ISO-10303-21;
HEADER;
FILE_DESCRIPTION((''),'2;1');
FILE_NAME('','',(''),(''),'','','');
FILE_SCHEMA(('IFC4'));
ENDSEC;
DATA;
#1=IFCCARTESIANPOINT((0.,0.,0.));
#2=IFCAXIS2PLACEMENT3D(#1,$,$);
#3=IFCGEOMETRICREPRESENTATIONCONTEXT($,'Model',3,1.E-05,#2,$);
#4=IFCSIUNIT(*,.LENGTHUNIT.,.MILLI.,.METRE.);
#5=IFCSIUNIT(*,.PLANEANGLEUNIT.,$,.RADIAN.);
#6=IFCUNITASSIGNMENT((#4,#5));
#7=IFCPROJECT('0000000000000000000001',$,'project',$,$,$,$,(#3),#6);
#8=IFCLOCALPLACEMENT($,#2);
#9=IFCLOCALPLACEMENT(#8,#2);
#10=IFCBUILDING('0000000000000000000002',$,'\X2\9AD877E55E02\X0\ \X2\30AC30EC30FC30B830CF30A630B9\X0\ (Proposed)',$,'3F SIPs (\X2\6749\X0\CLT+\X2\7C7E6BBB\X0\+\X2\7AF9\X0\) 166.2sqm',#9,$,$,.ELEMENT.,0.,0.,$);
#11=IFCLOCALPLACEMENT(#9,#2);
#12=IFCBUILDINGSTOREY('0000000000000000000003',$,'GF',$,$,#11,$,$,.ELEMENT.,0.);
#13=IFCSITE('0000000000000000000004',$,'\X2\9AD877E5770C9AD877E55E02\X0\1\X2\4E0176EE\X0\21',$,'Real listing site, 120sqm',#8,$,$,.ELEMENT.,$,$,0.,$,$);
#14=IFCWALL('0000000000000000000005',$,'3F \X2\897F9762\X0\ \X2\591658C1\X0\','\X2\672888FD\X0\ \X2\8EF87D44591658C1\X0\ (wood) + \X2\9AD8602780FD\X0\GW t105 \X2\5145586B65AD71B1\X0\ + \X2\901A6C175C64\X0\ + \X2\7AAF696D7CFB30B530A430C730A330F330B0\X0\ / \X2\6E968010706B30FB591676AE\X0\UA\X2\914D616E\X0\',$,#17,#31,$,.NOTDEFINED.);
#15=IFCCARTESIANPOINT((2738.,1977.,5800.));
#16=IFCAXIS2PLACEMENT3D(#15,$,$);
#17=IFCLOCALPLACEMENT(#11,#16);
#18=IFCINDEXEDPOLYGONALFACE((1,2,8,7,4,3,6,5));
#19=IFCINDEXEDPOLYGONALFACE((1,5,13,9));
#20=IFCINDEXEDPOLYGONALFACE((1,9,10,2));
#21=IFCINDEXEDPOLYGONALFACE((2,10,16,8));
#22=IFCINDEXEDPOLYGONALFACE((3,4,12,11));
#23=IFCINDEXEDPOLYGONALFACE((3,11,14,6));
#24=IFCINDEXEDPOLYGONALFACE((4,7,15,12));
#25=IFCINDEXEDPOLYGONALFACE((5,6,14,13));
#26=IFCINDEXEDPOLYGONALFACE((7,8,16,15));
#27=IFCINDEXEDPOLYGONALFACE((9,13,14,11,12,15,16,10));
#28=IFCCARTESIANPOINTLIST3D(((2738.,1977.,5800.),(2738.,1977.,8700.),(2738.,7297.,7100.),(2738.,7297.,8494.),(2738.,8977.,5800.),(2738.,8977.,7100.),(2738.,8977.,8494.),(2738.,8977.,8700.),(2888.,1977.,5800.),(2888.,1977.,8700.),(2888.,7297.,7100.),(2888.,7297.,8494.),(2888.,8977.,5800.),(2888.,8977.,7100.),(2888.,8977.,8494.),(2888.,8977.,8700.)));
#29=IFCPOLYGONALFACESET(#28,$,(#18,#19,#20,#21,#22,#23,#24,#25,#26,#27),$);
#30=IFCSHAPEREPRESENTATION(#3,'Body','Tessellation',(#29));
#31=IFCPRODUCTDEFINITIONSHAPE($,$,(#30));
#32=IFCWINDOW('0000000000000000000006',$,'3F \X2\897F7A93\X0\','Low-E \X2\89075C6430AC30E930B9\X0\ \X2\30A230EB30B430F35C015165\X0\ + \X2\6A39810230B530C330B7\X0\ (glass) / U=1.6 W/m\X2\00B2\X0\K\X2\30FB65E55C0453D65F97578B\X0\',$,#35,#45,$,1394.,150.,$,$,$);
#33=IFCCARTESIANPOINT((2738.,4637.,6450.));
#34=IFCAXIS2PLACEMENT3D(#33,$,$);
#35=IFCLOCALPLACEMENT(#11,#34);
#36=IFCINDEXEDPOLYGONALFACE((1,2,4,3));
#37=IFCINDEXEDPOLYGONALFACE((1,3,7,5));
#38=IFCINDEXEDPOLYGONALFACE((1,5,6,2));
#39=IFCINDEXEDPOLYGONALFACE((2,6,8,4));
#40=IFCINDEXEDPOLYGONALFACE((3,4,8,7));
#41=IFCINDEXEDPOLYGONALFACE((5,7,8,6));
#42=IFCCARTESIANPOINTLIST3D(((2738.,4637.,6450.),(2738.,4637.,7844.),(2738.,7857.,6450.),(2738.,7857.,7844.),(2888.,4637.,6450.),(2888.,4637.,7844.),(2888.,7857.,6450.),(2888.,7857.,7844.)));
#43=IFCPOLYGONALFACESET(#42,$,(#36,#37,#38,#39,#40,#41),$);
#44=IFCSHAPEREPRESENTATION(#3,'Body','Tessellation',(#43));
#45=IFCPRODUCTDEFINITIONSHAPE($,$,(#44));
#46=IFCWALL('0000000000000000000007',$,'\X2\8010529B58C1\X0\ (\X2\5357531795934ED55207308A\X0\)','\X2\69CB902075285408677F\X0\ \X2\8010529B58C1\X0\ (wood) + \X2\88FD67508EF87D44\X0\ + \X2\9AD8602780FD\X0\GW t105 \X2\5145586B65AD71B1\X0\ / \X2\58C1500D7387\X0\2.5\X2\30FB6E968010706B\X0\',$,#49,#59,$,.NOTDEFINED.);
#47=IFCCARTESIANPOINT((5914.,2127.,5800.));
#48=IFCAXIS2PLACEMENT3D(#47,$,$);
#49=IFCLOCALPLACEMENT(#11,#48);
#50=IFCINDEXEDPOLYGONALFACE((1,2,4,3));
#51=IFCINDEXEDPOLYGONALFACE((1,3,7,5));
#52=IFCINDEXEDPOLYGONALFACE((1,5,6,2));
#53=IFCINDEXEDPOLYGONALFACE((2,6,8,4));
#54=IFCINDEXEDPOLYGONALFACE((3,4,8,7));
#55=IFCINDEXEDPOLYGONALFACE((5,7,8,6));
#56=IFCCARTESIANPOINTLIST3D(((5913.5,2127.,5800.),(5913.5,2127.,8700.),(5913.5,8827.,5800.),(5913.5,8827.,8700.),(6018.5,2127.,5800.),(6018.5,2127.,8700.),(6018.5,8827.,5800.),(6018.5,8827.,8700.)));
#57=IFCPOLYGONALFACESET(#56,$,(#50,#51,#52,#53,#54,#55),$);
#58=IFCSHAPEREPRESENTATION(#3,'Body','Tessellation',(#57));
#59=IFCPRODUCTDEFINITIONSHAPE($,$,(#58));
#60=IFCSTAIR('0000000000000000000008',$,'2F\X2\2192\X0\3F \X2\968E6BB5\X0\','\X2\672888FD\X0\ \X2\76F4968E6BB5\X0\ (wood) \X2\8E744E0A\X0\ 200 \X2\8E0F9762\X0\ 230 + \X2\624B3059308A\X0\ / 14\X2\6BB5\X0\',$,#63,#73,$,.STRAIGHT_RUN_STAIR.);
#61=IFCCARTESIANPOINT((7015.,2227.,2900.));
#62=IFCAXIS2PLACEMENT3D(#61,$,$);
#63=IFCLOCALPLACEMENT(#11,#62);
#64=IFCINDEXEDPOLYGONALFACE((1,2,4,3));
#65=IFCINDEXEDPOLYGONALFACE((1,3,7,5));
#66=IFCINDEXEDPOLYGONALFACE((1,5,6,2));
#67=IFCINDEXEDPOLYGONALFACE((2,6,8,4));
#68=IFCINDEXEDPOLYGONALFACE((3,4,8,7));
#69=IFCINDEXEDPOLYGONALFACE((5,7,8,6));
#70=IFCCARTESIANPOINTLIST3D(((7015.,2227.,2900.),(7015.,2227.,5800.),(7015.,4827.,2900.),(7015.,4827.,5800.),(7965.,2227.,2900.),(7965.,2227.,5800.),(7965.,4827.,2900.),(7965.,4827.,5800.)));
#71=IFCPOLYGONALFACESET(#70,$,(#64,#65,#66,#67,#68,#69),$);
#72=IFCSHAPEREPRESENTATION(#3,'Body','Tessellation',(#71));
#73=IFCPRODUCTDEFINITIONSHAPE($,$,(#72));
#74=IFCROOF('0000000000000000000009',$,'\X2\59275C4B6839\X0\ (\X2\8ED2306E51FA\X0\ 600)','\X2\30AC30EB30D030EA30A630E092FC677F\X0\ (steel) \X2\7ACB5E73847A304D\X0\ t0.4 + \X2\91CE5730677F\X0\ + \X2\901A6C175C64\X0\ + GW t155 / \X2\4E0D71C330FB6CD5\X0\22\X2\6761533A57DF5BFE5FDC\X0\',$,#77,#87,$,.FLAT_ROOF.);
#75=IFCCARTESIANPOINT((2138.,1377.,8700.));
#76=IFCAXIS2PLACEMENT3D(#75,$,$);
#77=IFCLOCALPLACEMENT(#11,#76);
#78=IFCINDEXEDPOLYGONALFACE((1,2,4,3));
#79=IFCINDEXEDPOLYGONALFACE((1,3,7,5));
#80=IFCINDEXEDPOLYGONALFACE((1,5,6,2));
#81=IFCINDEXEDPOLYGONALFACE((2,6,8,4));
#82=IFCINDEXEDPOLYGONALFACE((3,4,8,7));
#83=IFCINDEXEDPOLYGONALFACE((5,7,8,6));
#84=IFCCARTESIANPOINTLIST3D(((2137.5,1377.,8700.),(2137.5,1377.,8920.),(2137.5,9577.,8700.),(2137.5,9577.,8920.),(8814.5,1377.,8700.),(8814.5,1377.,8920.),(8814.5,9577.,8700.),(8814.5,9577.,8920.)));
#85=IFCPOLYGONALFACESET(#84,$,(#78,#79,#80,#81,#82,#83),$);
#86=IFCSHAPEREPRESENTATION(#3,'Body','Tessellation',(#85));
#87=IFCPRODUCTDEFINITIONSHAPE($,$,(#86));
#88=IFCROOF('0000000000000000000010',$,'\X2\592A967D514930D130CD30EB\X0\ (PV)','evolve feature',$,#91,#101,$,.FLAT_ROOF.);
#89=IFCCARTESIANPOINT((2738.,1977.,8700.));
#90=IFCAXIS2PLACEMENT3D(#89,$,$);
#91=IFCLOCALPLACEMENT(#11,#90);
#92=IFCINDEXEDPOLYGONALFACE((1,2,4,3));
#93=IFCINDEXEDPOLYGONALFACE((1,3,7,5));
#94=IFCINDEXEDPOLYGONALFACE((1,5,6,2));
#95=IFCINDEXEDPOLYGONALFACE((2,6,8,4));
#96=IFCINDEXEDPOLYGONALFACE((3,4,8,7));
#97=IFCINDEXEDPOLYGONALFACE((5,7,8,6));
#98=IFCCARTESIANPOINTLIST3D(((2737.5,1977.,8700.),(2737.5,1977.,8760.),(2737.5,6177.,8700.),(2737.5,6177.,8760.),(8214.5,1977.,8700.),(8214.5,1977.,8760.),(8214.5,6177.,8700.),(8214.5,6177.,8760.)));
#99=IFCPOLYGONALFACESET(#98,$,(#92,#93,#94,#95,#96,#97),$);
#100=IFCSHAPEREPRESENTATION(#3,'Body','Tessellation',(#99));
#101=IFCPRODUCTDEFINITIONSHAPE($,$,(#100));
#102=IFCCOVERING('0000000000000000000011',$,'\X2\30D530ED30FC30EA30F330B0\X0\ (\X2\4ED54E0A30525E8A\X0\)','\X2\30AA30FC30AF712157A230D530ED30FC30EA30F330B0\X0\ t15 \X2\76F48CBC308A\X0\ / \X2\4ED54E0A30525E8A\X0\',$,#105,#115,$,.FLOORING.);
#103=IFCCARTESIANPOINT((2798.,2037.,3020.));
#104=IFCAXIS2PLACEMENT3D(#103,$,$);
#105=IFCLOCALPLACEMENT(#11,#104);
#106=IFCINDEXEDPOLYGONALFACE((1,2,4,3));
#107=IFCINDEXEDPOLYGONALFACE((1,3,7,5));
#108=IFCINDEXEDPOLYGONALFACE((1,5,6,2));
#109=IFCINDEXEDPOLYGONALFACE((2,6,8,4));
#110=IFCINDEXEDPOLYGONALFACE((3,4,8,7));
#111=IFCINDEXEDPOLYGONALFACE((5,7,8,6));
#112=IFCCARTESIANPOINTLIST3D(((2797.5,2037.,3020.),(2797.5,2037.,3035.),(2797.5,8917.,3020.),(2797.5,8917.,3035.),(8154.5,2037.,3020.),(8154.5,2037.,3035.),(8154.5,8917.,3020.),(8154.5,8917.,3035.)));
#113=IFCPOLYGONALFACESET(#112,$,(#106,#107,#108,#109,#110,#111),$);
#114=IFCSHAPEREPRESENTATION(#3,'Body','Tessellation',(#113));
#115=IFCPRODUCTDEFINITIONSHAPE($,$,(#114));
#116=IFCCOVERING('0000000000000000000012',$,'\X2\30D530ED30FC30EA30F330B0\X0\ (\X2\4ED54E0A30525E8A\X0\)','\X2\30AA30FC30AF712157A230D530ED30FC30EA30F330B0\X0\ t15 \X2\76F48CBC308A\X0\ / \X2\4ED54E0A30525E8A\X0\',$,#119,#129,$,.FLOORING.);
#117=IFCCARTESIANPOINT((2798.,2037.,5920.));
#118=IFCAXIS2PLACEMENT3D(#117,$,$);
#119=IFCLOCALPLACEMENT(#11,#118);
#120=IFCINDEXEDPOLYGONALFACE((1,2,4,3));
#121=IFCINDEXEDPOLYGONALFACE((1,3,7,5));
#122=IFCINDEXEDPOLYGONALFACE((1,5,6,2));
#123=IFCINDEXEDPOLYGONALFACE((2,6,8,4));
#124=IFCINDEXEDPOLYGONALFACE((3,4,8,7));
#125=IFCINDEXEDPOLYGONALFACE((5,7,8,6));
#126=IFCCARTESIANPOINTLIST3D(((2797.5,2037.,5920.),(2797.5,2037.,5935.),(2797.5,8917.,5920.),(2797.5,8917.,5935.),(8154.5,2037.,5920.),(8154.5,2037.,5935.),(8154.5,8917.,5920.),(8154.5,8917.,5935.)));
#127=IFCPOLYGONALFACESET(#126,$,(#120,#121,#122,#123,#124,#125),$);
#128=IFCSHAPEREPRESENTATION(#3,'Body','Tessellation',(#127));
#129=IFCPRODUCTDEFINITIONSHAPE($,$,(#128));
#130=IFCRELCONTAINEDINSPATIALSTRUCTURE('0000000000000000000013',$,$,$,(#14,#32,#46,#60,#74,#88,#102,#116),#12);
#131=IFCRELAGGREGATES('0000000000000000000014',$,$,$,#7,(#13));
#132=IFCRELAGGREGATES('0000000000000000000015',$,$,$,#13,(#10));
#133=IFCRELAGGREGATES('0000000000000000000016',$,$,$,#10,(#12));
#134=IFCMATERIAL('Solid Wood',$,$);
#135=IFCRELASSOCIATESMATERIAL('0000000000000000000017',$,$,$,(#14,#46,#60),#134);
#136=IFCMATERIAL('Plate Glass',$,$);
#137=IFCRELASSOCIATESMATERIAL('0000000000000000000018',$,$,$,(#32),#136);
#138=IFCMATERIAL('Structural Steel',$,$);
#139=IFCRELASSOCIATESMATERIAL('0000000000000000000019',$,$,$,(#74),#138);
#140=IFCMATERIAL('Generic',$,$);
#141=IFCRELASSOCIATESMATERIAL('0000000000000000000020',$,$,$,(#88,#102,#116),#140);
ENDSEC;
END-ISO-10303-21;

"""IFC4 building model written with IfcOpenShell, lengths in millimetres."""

from ifc_helpers import new_model, si_unit, frame, frame_2d, origin, place, context, project, spatial, rectangle, extrude, material, element, fill, save


model = new_model("IFC4")

# Units and contexts
model_context = context("Model", 3, precision=1e-05, world=origin())
ifc_project = project(units=[si_unit("LENGTHUNIT", "METRE", prefix="MILLI"), si_unit("PLANEANGLEUNIT", "RADIAN")], contexts=[model_context])

# Site, building, storey
site_placement = place(None, origin())
site = spatial("IfcSite", under=ifc_project, at=site_placement, Name="高知県高知市1丁目21", ObjectType="Real listing site, 120sqm", CompositionType="ELEMENT", RefElevation=0.0)
building_placement = place(site_placement, origin())
building = spatial("IfcBuilding", under=site, at=building_placement, Name="高知市 ガレージハウス (Proposed)", ObjectType="3F SIPs (杉CLT+籾殻+竹) 166.2sqm", CompositionType="ELEMENT", ElevationOfRefHeight=0.0, ElevationOfTerrain=0.0)
storey_placement = place(building_placement, origin())
storey = spatial("IfcBuildingStorey", under=building, at=storey_placement, Name="GF", CompositionType="ELEMENT", Elevation=0.0)

# Shared definitions
ifc_material_1 = material(Name="Solid Wood")

# Shared definitions
ifc_material_2 = material(Name="Plate Glass")

# Shared definitions
ifc_material_3 = material(Name="Generic")

# Wall, opening, window
wall_1_placement = place(storey_placement, frame((2738.0, 1977.0, 5800.0)))
wall_1 = element("IfcWall", 1, at=wall_1_placement, inside=storey, material=ifc_material_1, Name="3F 西面 外壁", Description="木製 軸組外壁 (wood) + 高性能GW t105 充填断熱 + 通気層 + 窯業系サイディング / 準耐火・外皮UA配慮", PredefinedType="NOTDEFINED", context=model_context, shape_type="SweptSolid", body=[
    extrude(rectangle(XDim=150.0, YDim=7000.0, at=frame_2d((75.0, 3500.0))), frame((2738.0, 1977.0, 5800.0)), (0.0, 0.0, 1.0), 2900.0),
])
opening_1_placement = place(storey_placement, frame((2738.0, 4637.0, 6450.0)))
opening_1 = element("IfcOpeningElement", 2, at=opening_1_placement, cuts=wall_1, PredefinedType="NOTDEFINED", context=model_context, shape_type="SweptSolid", body=[
    extrude(rectangle(XDim=150.0, YDim=3220.0, at=frame_2d((75.0, 1610.0))), frame((2738.0, 4637.0, 6450.0)), (0.0, 0.0, 1.0), 1394.0),
])
window_1_placement = place(storey_placement, frame((2738.0, 4637.0, 6450.0)))
window_1 = element("IfcWindow", 3, at=window_1_placement, inside=storey, material=ifc_material_2, Name="3F 西窓", Description="Low-E 複層ガラス アルゴン封入 + 樹脂サッシ (glass) / U=1.6 W/m²K・日射取得型", OverallHeight=1394.0, OverallWidth=150.0, context=model_context, shape_type="SweptSolid", body=[
    extrude(rectangle(XDim=150.0, YDim=3220.0, at=frame_2d((75.0, 1610.0))), frame((2738.0, 4637.0, 6450.0)), (0.0, 0.0, 1.0), 1394.0),
])
fill(opening_1, window_1)

# Wall
wall_2_placement = place(storey_placement, frame((5914.0, 2127.0, 5800.0)))
element("IfcWall", 4, at=wall_2_placement, inside=storey, material=ifc_material_1, Name="耐力壁 (南北間仕切り)", Description="構造用合板 耐力壁 (wood) + 製材軸組 + 高性能GW t105 充填断熱 / 壁倍率2.5・準耐火", PredefinedType="NOTDEFINED", context=model_context, shape_type="SweptSolid", body=[
    extrude(rectangle(XDim=105.0, YDim=6700.0, at=frame_2d((52.0, 3350.0))), frame((5914.0, 2127.0, 5800.0)), (0.0, 0.0, 1.0), 2900.0),
])

# Stair
stair_placement = place(storey_placement, frame((7015.0, 2227.0, 2900.0)))
element("IfcStair", 5, at=stair_placement, inside=storey, material=ifc_material_1, Name="2F→3F 階段", Description="木製 直階段 (wood) 蹴上 200 踏面 230 + 手すり / 14段", PredefinedType="STRAIGHT_RUN_STAIR", context=model_context, shape_type="SweptSolid", body=[
    extrude(rectangle(XDim=950.0, YDim=2600.0, at=frame_2d((475.0, 1300.0))), frame((7015.0, 2227.0, 2900.0)), (0.0, 0.0, 1.0), 2900.0),
])

# Roofs
ifc_material_4 = material(Name="Structural Steel")
roof_1_placement = place(storey_placement, frame((2138.0, 1377.0, 8700.0)))
element("IfcRoof", 6, at=roof_1_placement, inside=storey, material=ifc_material_4, Name="大屋根 (軒の出 600)", Description="ガルバリウム鋼板 (steel) 立平葺き t0.4 + 野地板 + 通気層 + GW t155 / 不燃・法22条区域対応", PredefinedType="FLAT_ROOF", context=model_context, shape_type="SweptSolid", body=[
    extrude(rectangle(XDim=6677.0, YDim=8200.0, at=frame_2d((3338.0, 4100.0))), frame((2138.0, 1377.0, 8700.0)), (0.0, 0.0, 1.0), 220.0),
])
roof_2_placement = place(storey_placement, frame((2738.0, 1977.0, 8700.0)))
element("IfcRoof", 7, at=roof_2_placement, inside=storey, material=ifc_material_3, Name="太陽光パネル (PV)", Description="evolve feature", PredefinedType="FLAT_ROOF", context=model_context, shape_type="SweptSolid", body=[
    extrude(rectangle(XDim=5477.0, YDim=4200.0, at=frame_2d((2738.0, 2100.0))), frame((2738.0, 1977.0, 8700.0)), (0.0, 0.0, 1.0), 60.0),
])

# Coverings
covering_1_placement = place(storey_placement, frame((2798.0, 2037.0, 3020.0)))
element("IfcCovering", 8, at=covering_1_placement, inside=storey, material=ifc_material_3, Name="フローリング (仕上げ床)", Description="オーク無垢フローリング t15 直貼り / 仕上げ床", PredefinedType="FLOORING", context=model_context, shape_type="SweptSolid", body=[
    extrude(rectangle(XDim=5357.0, YDim=6880.0, at=frame_2d((2678.0, 3440.0))), frame((2798.0, 2037.0, 3020.0)), (0.0, 0.0, 1.0), 15.0),
])
covering_2_placement = place(storey_placement, frame((2798.0, 2037.0, 5920.0)))
element("IfcCovering", 9, at=covering_2_placement, inside=storey, material=ifc_material_3, Name="フローリング (仕上げ床)", Description="オーク無垢フローリング t15 直貼り / 仕上げ床", PredefinedType="FLOORING", context=model_context, shape_type="SweptSolid", body=[
    extrude(rectangle(XDim=5357.0, YDim=6880.0, at=frame_2d((2678.0, 3440.0))), frame((2798.0, 2037.0, 5920.0)), (0.0, 0.0, 1.0), 15.0),
])

save(model, "model.ifc")
